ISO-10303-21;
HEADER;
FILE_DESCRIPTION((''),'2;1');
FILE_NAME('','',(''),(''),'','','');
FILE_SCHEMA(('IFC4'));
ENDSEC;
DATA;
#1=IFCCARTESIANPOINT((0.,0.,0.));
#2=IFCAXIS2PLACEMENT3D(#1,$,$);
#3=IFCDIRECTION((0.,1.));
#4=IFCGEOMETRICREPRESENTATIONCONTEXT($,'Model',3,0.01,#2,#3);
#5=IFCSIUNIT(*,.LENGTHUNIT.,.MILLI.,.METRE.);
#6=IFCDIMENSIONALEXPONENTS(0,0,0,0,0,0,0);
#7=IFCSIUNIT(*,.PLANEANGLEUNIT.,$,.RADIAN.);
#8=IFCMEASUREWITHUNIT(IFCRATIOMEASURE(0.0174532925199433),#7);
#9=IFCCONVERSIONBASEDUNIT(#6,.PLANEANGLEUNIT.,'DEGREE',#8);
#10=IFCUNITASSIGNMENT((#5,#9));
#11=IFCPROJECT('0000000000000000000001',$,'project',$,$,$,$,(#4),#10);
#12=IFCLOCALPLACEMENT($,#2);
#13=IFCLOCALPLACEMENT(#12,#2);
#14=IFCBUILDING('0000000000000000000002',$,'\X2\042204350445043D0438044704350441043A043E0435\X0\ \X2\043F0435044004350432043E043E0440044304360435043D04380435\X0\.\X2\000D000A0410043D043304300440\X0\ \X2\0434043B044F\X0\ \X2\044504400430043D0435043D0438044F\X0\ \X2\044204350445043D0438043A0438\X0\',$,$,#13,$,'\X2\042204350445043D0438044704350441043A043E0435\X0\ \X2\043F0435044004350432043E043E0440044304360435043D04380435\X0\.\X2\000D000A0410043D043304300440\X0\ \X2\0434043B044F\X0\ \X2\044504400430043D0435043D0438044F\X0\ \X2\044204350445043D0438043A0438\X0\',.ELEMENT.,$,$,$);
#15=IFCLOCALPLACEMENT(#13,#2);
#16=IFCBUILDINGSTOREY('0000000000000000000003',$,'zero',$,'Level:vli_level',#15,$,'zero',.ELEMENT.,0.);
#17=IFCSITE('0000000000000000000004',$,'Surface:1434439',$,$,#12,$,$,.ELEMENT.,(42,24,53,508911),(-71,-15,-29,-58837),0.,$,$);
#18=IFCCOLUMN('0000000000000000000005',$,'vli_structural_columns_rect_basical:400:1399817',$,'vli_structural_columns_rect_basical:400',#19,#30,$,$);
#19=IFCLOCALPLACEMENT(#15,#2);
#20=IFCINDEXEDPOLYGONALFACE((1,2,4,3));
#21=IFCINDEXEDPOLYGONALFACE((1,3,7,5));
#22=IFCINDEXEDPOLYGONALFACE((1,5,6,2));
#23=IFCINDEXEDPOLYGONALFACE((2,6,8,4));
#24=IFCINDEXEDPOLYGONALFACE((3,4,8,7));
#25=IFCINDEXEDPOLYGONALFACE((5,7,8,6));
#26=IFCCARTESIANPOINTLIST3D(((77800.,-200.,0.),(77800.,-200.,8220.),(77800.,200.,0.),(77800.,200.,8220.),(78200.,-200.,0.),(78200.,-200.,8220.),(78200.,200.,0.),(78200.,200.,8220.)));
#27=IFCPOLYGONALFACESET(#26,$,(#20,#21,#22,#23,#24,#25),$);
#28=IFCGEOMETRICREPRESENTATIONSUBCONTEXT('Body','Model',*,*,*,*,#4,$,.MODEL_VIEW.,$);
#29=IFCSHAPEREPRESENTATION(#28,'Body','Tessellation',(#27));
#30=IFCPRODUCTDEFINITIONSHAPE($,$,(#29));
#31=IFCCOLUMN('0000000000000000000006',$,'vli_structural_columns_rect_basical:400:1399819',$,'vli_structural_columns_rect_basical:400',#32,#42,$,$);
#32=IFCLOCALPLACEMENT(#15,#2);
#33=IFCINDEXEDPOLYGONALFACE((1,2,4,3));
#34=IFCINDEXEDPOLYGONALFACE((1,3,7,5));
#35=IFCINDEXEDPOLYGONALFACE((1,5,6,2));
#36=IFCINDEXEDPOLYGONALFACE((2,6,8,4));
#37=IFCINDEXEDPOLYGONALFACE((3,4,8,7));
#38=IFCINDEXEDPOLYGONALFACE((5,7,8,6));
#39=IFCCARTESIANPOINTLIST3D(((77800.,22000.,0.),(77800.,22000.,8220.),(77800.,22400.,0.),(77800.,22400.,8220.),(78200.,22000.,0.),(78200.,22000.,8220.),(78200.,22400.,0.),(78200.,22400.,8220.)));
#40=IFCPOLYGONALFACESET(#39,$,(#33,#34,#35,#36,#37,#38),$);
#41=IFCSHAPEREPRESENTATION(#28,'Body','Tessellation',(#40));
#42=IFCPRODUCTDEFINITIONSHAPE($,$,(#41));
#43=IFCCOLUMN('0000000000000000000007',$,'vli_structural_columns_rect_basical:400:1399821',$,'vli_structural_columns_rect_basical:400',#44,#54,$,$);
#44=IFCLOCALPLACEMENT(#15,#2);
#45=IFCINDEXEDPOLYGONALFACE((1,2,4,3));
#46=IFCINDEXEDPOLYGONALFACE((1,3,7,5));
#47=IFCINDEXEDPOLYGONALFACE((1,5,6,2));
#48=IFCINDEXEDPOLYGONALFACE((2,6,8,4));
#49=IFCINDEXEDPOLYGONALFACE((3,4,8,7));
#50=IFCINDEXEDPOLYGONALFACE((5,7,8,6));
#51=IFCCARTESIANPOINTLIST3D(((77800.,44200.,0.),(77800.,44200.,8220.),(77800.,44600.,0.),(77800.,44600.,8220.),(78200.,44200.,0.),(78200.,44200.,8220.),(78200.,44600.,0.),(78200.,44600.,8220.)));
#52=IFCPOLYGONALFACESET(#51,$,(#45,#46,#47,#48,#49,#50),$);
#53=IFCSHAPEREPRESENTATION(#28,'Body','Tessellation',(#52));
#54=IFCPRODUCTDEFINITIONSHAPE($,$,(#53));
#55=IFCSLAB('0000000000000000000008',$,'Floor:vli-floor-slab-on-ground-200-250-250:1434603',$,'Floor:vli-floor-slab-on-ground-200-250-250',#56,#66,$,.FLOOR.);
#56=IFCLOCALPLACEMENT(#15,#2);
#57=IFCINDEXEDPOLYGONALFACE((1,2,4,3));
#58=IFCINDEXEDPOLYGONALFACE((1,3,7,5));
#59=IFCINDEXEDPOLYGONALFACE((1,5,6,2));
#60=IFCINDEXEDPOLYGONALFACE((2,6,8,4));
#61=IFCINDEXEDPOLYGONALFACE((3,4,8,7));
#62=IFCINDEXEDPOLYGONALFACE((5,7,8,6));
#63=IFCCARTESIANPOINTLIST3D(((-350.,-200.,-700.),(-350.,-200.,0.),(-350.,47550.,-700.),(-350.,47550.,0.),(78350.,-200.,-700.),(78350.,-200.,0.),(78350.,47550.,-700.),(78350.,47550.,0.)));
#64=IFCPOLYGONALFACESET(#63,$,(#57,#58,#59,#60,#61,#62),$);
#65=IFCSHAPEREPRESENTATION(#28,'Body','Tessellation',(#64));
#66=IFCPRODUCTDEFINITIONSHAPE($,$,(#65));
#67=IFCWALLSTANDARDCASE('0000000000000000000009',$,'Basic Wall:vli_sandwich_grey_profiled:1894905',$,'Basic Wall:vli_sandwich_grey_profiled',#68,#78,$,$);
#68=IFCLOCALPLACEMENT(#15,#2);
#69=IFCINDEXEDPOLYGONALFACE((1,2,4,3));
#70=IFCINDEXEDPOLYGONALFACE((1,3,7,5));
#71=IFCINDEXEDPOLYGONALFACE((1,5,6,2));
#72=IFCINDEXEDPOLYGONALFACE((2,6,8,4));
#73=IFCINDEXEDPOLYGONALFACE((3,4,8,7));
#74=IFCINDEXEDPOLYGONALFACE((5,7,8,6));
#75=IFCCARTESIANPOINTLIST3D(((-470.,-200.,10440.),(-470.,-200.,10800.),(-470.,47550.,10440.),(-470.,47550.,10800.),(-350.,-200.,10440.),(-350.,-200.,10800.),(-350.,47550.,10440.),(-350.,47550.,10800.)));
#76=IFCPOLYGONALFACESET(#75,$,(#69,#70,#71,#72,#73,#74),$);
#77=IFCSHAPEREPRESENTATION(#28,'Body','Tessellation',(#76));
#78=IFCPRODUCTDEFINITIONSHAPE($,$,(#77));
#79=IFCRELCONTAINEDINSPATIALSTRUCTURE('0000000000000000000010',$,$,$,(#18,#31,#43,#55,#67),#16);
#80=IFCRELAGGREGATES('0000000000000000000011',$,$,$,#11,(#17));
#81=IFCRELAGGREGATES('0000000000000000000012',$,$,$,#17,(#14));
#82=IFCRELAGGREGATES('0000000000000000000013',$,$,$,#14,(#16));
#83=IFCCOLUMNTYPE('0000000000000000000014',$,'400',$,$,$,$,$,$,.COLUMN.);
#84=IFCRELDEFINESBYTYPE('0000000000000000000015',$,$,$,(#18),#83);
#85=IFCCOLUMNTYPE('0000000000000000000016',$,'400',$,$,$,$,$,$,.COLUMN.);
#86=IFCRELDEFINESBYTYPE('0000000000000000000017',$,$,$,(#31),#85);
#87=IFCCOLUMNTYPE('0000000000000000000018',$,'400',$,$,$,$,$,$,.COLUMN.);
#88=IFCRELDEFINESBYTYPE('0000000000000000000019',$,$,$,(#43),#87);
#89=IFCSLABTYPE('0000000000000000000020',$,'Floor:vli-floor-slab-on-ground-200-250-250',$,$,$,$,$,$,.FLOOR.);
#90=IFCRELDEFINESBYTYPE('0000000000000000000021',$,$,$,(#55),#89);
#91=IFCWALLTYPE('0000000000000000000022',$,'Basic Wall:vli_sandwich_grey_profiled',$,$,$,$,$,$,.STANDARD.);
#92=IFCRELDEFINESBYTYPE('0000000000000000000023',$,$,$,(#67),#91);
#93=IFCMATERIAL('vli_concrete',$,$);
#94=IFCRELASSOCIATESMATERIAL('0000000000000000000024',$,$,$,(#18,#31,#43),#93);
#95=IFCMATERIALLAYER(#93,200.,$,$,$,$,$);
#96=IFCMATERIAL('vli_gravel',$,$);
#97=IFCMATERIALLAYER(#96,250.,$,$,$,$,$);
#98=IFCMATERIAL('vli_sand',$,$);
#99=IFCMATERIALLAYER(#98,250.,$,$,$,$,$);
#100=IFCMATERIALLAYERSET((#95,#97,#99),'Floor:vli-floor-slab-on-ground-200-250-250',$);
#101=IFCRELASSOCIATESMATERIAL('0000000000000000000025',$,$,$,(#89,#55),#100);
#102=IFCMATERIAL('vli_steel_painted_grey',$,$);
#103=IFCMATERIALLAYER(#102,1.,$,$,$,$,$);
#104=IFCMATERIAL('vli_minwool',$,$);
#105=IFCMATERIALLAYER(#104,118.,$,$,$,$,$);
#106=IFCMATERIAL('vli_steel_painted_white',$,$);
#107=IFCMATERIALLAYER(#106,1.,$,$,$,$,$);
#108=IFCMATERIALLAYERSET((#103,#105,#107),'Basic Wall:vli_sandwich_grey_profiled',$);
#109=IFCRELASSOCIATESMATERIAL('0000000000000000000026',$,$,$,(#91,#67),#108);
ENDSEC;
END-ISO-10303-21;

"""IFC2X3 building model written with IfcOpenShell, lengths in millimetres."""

from ifc_helpers import new_model, entity, si_unit, converted_unit, direction, frame, frame_2d, origin, origin_2d_with_axis, place, context, subcontext, project, spatial, rectangle, extrude, source, transform, mapped, material, layer, layer_set, layer_usage, type_object, type_shapes, element, save


model = new_model("IFC2X3")

# Units and contexts
model_context = context("Model", 3, precision=0.01, world=origin(), true_north=direction((0.0, 1.0)))
body_context = subcontext(model_context, "Body", "Model", "MODEL_VIEW")
ifc_project = project(units=[si_unit("LENGTHUNIT", "METRE", prefix="MILLI"), converted_unit("PLANEANGLEUNIT", "DEGREE", entity("IfcRatioMeasure", 0.0174532925199433), si_unit("PLANEANGLEUNIT", "RADIAN"), dimensions=[0, 0, 0, 0, 0, 0, 0])], contexts=[model_context])

# Site, building, storey
site_placement = place(None, origin())
site = spatial("IfcSite", under=ifc_project, at=site_placement, Name="Surface:1434439", CompositionType="ELEMENT", RefLatitude=(42, 24, 53, 508911), RefLongitude=(-71, -15, -29, -58837), RefElevation=0.0)
building_placement = place(site_placement, origin())
building = spatial("IfcBuilding", under=site, at=building_placement, Name="Техническое перевооружение.\r\nАнгар для хранения техники", LongName="Техническое перевооружение.\r\nАнгар для хранения техники", CompositionType="ELEMENT")
storey_placement = place(building_placement, origin())
storey = spatial("IfcBuildingStorey", under=building, at=storey_placement, Name="zero", ObjectType="Level:vli_level", LongName="zero", CompositionType="ELEMENT", Elevation=0.0)

# Columns
ifc_material_1 = material(Name="vli_concrete")
column_type_1 = type_object("IfcColumnType", Name="400", PredefinedType="COLUMN")
shared_shape_1 = source(origin(), body_context, "Body", "SweptSolid", [
    extrude(rectangle(XDim=400.0, YDim=400.0, at=frame_2d((0.0, 0.0), x_axis=(1.0, 0.0))), frame((78000.0, 0.0, 0.0), z_axis=(0.0, 0.0, 1.0), x_axis=(0.0, -1.0, 0.0)), (0.0, 0.0, 1.0), 8220.0),
])
type_shapes(column_type_1, [shared_shape_1])
column_1_placement = place(storey_placement, origin())
element("IfcColumn", 1, at=column_1_placement, inside=storey, type_object=column_type_1, material=ifc_material_1, Name="vli_structural_columns_rect_basical:400:1399817", ObjectType="vli_structural_columns_rect_basical:400", context=body_context, shape_type="MappedRepresentation", body=[
    mapped(shared_shape_1, transform((0.0, 0.0, 0.0), scale=1.0)),
])
column_type_2 = type_object("IfcColumnType", Name="400", PredefinedType="COLUMN")
shared_shape_2 = source(origin(), body_context, "Body", "SweptSolid", [
    extrude(rectangle(XDim=400.0, YDim=400.0, at=frame_2d((0.0, 0.0), x_axis=(1.0, 0.0))), frame((78000.0, 22200.0, 0.0), z_axis=(0.0, 0.0, 1.0), x_axis=(0.0, -1.0, 0.0)), (0.0, 0.0, 1.0), 8220.0),
])
type_shapes(column_type_2, [shared_shape_2])
column_2_placement = place(storey_placement, origin())
element("IfcColumn", 2, at=column_2_placement, inside=storey, type_object=column_type_2, material=ifc_material_1, Name="vli_structural_columns_rect_basical:400:1399819", ObjectType="vli_structural_columns_rect_basical:400", context=body_context, shape_type="MappedRepresentation", body=[
    mapped(shared_shape_2, transform((0.0, 0.0, 0.0), scale=1.0)),
])
column_type_3 = type_object("IfcColumnType", Name="400", PredefinedType="COLUMN")
shared_shape_3 = source(origin(), body_context, "Body", "SweptSolid", [
    extrude(rectangle(XDim=400.0, YDim=400.0, at=frame_2d((0.0, 0.0), x_axis=(1.0, 0.0))), frame((78000.0, 44400.0, 0.0), z_axis=(0.0, 0.0, 1.0), x_axis=(0.0, -1.0, 0.0)), (0.0, 0.0, 1.0), 8220.0),
])
type_shapes(column_type_3, [shared_shape_3])
column_3_placement = place(storey_placement, origin())
element("IfcColumn", 3, at=column_3_placement, inside=storey, type_object=column_type_3, material=ifc_material_1, Name="vli_structural_columns_rect_basical:400:1399821", ObjectType="vli_structural_columns_rect_basical:400", context=body_context, shape_type="MappedRepresentation", body=[
    mapped(shared_shape_3, transform((0.0, 0.0, 0.0), scale=1.0)),
])

# Slab
ifc_layer_1 = layer(ifc_material_1, 200.0)
ifc_material_2 = material(Name="vli_gravel")
ifc_layer_2 = layer(ifc_material_2, 250.0)
ifc_material_3 = material(Name="vli_sand")
ifc_layer_3 = layer(ifc_material_3, 250.0)
ifc_layer_set_1 = layer_set([ifc_layer_1, ifc_layer_2, ifc_layer_3], Name="Floor:vli-floor-slab-on-ground-200-250-250")
ifc_layer_usage_1 = layer_usage(ifc_layer_set_1, "AXIS3", "POSITIVE", 0.0)
slab_type = type_object("IfcSlabType", Name="Floor:vli-floor-slab-on-ground-200-250-250", PredefinedType="FLOOR", material=ifc_layer_set_1)
slab_placement = place(storey_placement, origin())
element("IfcSlab", 4, at=slab_placement, inside=storey, type_object=slab_type, material=ifc_layer_usage_1, Name="Floor:vli-floor-slab-on-ground-200-250-250:1434603", ObjectType="Floor:vli-floor-slab-on-ground-200-250-250", PredefinedType="FLOOR", context=body_context, shape_type="SweptSolid", body=[
    extrude(rectangle(XDim=47750.0, YDim=78700.0, at=origin_2d_with_axis()), frame((39000.0, 23675.0, 0.0), z_axis=(0.0, 0.0, -1.0), x_axis=(0.0, 1.0, 0.0)), (0.0, 0.0, 1.0), 700.0),
])

# Wall
ifc_material_4 = material(Name="vli_steel_painted_grey")
ifc_layer_4 = layer(ifc_material_4, 1.0)
ifc_material_5 = material(Name="vli_minwool")
ifc_layer_5 = layer(ifc_material_5, 118.0)
ifc_material_6 = material(Name="vli_steel_painted_white")
ifc_layer_6 = layer(ifc_material_6, 1.0)
ifc_layer_set_2 = layer_set([ifc_layer_4, ifc_layer_5, ifc_layer_6], Name="Basic Wall:vli_sandwich_grey_profiled")
ifc_layer_usage_2 = layer_usage(ifc_layer_set_2, "AXIS2", "POSITIVE", -60.0)
wall_type = type_object("IfcWallType", Name="Basic Wall:vli_sandwich_grey_profiled", PredefinedType="STANDARD", material=ifc_layer_set_2)
wall_placement = place(storey_placement, frame((-410.0, 47550.0, 10440.0), z_axis=(0.0, 0.0, 1.0), x_axis=(0.0, -1.0, 0.0)))
element("IfcWallStandardCase", 5, at=wall_placement, inside=storey, type_object=wall_type, material=ifc_layer_usage_2, Name="Basic Wall:vli_sandwich_grey_profiled:1894905", ObjectType="Basic Wall:vli_sandwich_grey_profiled", context=body_context, shape_type="SweptSolid", body=[
    extrude(rectangle(XDim=47750.0, YDim=120.0, at=frame_2d((23875.0, 0.0), x_axis=(-1.0, 0.0))), origin(), (0.0, 0.0, 1.0), 360.0),
])

save(model, "model.ifc")
